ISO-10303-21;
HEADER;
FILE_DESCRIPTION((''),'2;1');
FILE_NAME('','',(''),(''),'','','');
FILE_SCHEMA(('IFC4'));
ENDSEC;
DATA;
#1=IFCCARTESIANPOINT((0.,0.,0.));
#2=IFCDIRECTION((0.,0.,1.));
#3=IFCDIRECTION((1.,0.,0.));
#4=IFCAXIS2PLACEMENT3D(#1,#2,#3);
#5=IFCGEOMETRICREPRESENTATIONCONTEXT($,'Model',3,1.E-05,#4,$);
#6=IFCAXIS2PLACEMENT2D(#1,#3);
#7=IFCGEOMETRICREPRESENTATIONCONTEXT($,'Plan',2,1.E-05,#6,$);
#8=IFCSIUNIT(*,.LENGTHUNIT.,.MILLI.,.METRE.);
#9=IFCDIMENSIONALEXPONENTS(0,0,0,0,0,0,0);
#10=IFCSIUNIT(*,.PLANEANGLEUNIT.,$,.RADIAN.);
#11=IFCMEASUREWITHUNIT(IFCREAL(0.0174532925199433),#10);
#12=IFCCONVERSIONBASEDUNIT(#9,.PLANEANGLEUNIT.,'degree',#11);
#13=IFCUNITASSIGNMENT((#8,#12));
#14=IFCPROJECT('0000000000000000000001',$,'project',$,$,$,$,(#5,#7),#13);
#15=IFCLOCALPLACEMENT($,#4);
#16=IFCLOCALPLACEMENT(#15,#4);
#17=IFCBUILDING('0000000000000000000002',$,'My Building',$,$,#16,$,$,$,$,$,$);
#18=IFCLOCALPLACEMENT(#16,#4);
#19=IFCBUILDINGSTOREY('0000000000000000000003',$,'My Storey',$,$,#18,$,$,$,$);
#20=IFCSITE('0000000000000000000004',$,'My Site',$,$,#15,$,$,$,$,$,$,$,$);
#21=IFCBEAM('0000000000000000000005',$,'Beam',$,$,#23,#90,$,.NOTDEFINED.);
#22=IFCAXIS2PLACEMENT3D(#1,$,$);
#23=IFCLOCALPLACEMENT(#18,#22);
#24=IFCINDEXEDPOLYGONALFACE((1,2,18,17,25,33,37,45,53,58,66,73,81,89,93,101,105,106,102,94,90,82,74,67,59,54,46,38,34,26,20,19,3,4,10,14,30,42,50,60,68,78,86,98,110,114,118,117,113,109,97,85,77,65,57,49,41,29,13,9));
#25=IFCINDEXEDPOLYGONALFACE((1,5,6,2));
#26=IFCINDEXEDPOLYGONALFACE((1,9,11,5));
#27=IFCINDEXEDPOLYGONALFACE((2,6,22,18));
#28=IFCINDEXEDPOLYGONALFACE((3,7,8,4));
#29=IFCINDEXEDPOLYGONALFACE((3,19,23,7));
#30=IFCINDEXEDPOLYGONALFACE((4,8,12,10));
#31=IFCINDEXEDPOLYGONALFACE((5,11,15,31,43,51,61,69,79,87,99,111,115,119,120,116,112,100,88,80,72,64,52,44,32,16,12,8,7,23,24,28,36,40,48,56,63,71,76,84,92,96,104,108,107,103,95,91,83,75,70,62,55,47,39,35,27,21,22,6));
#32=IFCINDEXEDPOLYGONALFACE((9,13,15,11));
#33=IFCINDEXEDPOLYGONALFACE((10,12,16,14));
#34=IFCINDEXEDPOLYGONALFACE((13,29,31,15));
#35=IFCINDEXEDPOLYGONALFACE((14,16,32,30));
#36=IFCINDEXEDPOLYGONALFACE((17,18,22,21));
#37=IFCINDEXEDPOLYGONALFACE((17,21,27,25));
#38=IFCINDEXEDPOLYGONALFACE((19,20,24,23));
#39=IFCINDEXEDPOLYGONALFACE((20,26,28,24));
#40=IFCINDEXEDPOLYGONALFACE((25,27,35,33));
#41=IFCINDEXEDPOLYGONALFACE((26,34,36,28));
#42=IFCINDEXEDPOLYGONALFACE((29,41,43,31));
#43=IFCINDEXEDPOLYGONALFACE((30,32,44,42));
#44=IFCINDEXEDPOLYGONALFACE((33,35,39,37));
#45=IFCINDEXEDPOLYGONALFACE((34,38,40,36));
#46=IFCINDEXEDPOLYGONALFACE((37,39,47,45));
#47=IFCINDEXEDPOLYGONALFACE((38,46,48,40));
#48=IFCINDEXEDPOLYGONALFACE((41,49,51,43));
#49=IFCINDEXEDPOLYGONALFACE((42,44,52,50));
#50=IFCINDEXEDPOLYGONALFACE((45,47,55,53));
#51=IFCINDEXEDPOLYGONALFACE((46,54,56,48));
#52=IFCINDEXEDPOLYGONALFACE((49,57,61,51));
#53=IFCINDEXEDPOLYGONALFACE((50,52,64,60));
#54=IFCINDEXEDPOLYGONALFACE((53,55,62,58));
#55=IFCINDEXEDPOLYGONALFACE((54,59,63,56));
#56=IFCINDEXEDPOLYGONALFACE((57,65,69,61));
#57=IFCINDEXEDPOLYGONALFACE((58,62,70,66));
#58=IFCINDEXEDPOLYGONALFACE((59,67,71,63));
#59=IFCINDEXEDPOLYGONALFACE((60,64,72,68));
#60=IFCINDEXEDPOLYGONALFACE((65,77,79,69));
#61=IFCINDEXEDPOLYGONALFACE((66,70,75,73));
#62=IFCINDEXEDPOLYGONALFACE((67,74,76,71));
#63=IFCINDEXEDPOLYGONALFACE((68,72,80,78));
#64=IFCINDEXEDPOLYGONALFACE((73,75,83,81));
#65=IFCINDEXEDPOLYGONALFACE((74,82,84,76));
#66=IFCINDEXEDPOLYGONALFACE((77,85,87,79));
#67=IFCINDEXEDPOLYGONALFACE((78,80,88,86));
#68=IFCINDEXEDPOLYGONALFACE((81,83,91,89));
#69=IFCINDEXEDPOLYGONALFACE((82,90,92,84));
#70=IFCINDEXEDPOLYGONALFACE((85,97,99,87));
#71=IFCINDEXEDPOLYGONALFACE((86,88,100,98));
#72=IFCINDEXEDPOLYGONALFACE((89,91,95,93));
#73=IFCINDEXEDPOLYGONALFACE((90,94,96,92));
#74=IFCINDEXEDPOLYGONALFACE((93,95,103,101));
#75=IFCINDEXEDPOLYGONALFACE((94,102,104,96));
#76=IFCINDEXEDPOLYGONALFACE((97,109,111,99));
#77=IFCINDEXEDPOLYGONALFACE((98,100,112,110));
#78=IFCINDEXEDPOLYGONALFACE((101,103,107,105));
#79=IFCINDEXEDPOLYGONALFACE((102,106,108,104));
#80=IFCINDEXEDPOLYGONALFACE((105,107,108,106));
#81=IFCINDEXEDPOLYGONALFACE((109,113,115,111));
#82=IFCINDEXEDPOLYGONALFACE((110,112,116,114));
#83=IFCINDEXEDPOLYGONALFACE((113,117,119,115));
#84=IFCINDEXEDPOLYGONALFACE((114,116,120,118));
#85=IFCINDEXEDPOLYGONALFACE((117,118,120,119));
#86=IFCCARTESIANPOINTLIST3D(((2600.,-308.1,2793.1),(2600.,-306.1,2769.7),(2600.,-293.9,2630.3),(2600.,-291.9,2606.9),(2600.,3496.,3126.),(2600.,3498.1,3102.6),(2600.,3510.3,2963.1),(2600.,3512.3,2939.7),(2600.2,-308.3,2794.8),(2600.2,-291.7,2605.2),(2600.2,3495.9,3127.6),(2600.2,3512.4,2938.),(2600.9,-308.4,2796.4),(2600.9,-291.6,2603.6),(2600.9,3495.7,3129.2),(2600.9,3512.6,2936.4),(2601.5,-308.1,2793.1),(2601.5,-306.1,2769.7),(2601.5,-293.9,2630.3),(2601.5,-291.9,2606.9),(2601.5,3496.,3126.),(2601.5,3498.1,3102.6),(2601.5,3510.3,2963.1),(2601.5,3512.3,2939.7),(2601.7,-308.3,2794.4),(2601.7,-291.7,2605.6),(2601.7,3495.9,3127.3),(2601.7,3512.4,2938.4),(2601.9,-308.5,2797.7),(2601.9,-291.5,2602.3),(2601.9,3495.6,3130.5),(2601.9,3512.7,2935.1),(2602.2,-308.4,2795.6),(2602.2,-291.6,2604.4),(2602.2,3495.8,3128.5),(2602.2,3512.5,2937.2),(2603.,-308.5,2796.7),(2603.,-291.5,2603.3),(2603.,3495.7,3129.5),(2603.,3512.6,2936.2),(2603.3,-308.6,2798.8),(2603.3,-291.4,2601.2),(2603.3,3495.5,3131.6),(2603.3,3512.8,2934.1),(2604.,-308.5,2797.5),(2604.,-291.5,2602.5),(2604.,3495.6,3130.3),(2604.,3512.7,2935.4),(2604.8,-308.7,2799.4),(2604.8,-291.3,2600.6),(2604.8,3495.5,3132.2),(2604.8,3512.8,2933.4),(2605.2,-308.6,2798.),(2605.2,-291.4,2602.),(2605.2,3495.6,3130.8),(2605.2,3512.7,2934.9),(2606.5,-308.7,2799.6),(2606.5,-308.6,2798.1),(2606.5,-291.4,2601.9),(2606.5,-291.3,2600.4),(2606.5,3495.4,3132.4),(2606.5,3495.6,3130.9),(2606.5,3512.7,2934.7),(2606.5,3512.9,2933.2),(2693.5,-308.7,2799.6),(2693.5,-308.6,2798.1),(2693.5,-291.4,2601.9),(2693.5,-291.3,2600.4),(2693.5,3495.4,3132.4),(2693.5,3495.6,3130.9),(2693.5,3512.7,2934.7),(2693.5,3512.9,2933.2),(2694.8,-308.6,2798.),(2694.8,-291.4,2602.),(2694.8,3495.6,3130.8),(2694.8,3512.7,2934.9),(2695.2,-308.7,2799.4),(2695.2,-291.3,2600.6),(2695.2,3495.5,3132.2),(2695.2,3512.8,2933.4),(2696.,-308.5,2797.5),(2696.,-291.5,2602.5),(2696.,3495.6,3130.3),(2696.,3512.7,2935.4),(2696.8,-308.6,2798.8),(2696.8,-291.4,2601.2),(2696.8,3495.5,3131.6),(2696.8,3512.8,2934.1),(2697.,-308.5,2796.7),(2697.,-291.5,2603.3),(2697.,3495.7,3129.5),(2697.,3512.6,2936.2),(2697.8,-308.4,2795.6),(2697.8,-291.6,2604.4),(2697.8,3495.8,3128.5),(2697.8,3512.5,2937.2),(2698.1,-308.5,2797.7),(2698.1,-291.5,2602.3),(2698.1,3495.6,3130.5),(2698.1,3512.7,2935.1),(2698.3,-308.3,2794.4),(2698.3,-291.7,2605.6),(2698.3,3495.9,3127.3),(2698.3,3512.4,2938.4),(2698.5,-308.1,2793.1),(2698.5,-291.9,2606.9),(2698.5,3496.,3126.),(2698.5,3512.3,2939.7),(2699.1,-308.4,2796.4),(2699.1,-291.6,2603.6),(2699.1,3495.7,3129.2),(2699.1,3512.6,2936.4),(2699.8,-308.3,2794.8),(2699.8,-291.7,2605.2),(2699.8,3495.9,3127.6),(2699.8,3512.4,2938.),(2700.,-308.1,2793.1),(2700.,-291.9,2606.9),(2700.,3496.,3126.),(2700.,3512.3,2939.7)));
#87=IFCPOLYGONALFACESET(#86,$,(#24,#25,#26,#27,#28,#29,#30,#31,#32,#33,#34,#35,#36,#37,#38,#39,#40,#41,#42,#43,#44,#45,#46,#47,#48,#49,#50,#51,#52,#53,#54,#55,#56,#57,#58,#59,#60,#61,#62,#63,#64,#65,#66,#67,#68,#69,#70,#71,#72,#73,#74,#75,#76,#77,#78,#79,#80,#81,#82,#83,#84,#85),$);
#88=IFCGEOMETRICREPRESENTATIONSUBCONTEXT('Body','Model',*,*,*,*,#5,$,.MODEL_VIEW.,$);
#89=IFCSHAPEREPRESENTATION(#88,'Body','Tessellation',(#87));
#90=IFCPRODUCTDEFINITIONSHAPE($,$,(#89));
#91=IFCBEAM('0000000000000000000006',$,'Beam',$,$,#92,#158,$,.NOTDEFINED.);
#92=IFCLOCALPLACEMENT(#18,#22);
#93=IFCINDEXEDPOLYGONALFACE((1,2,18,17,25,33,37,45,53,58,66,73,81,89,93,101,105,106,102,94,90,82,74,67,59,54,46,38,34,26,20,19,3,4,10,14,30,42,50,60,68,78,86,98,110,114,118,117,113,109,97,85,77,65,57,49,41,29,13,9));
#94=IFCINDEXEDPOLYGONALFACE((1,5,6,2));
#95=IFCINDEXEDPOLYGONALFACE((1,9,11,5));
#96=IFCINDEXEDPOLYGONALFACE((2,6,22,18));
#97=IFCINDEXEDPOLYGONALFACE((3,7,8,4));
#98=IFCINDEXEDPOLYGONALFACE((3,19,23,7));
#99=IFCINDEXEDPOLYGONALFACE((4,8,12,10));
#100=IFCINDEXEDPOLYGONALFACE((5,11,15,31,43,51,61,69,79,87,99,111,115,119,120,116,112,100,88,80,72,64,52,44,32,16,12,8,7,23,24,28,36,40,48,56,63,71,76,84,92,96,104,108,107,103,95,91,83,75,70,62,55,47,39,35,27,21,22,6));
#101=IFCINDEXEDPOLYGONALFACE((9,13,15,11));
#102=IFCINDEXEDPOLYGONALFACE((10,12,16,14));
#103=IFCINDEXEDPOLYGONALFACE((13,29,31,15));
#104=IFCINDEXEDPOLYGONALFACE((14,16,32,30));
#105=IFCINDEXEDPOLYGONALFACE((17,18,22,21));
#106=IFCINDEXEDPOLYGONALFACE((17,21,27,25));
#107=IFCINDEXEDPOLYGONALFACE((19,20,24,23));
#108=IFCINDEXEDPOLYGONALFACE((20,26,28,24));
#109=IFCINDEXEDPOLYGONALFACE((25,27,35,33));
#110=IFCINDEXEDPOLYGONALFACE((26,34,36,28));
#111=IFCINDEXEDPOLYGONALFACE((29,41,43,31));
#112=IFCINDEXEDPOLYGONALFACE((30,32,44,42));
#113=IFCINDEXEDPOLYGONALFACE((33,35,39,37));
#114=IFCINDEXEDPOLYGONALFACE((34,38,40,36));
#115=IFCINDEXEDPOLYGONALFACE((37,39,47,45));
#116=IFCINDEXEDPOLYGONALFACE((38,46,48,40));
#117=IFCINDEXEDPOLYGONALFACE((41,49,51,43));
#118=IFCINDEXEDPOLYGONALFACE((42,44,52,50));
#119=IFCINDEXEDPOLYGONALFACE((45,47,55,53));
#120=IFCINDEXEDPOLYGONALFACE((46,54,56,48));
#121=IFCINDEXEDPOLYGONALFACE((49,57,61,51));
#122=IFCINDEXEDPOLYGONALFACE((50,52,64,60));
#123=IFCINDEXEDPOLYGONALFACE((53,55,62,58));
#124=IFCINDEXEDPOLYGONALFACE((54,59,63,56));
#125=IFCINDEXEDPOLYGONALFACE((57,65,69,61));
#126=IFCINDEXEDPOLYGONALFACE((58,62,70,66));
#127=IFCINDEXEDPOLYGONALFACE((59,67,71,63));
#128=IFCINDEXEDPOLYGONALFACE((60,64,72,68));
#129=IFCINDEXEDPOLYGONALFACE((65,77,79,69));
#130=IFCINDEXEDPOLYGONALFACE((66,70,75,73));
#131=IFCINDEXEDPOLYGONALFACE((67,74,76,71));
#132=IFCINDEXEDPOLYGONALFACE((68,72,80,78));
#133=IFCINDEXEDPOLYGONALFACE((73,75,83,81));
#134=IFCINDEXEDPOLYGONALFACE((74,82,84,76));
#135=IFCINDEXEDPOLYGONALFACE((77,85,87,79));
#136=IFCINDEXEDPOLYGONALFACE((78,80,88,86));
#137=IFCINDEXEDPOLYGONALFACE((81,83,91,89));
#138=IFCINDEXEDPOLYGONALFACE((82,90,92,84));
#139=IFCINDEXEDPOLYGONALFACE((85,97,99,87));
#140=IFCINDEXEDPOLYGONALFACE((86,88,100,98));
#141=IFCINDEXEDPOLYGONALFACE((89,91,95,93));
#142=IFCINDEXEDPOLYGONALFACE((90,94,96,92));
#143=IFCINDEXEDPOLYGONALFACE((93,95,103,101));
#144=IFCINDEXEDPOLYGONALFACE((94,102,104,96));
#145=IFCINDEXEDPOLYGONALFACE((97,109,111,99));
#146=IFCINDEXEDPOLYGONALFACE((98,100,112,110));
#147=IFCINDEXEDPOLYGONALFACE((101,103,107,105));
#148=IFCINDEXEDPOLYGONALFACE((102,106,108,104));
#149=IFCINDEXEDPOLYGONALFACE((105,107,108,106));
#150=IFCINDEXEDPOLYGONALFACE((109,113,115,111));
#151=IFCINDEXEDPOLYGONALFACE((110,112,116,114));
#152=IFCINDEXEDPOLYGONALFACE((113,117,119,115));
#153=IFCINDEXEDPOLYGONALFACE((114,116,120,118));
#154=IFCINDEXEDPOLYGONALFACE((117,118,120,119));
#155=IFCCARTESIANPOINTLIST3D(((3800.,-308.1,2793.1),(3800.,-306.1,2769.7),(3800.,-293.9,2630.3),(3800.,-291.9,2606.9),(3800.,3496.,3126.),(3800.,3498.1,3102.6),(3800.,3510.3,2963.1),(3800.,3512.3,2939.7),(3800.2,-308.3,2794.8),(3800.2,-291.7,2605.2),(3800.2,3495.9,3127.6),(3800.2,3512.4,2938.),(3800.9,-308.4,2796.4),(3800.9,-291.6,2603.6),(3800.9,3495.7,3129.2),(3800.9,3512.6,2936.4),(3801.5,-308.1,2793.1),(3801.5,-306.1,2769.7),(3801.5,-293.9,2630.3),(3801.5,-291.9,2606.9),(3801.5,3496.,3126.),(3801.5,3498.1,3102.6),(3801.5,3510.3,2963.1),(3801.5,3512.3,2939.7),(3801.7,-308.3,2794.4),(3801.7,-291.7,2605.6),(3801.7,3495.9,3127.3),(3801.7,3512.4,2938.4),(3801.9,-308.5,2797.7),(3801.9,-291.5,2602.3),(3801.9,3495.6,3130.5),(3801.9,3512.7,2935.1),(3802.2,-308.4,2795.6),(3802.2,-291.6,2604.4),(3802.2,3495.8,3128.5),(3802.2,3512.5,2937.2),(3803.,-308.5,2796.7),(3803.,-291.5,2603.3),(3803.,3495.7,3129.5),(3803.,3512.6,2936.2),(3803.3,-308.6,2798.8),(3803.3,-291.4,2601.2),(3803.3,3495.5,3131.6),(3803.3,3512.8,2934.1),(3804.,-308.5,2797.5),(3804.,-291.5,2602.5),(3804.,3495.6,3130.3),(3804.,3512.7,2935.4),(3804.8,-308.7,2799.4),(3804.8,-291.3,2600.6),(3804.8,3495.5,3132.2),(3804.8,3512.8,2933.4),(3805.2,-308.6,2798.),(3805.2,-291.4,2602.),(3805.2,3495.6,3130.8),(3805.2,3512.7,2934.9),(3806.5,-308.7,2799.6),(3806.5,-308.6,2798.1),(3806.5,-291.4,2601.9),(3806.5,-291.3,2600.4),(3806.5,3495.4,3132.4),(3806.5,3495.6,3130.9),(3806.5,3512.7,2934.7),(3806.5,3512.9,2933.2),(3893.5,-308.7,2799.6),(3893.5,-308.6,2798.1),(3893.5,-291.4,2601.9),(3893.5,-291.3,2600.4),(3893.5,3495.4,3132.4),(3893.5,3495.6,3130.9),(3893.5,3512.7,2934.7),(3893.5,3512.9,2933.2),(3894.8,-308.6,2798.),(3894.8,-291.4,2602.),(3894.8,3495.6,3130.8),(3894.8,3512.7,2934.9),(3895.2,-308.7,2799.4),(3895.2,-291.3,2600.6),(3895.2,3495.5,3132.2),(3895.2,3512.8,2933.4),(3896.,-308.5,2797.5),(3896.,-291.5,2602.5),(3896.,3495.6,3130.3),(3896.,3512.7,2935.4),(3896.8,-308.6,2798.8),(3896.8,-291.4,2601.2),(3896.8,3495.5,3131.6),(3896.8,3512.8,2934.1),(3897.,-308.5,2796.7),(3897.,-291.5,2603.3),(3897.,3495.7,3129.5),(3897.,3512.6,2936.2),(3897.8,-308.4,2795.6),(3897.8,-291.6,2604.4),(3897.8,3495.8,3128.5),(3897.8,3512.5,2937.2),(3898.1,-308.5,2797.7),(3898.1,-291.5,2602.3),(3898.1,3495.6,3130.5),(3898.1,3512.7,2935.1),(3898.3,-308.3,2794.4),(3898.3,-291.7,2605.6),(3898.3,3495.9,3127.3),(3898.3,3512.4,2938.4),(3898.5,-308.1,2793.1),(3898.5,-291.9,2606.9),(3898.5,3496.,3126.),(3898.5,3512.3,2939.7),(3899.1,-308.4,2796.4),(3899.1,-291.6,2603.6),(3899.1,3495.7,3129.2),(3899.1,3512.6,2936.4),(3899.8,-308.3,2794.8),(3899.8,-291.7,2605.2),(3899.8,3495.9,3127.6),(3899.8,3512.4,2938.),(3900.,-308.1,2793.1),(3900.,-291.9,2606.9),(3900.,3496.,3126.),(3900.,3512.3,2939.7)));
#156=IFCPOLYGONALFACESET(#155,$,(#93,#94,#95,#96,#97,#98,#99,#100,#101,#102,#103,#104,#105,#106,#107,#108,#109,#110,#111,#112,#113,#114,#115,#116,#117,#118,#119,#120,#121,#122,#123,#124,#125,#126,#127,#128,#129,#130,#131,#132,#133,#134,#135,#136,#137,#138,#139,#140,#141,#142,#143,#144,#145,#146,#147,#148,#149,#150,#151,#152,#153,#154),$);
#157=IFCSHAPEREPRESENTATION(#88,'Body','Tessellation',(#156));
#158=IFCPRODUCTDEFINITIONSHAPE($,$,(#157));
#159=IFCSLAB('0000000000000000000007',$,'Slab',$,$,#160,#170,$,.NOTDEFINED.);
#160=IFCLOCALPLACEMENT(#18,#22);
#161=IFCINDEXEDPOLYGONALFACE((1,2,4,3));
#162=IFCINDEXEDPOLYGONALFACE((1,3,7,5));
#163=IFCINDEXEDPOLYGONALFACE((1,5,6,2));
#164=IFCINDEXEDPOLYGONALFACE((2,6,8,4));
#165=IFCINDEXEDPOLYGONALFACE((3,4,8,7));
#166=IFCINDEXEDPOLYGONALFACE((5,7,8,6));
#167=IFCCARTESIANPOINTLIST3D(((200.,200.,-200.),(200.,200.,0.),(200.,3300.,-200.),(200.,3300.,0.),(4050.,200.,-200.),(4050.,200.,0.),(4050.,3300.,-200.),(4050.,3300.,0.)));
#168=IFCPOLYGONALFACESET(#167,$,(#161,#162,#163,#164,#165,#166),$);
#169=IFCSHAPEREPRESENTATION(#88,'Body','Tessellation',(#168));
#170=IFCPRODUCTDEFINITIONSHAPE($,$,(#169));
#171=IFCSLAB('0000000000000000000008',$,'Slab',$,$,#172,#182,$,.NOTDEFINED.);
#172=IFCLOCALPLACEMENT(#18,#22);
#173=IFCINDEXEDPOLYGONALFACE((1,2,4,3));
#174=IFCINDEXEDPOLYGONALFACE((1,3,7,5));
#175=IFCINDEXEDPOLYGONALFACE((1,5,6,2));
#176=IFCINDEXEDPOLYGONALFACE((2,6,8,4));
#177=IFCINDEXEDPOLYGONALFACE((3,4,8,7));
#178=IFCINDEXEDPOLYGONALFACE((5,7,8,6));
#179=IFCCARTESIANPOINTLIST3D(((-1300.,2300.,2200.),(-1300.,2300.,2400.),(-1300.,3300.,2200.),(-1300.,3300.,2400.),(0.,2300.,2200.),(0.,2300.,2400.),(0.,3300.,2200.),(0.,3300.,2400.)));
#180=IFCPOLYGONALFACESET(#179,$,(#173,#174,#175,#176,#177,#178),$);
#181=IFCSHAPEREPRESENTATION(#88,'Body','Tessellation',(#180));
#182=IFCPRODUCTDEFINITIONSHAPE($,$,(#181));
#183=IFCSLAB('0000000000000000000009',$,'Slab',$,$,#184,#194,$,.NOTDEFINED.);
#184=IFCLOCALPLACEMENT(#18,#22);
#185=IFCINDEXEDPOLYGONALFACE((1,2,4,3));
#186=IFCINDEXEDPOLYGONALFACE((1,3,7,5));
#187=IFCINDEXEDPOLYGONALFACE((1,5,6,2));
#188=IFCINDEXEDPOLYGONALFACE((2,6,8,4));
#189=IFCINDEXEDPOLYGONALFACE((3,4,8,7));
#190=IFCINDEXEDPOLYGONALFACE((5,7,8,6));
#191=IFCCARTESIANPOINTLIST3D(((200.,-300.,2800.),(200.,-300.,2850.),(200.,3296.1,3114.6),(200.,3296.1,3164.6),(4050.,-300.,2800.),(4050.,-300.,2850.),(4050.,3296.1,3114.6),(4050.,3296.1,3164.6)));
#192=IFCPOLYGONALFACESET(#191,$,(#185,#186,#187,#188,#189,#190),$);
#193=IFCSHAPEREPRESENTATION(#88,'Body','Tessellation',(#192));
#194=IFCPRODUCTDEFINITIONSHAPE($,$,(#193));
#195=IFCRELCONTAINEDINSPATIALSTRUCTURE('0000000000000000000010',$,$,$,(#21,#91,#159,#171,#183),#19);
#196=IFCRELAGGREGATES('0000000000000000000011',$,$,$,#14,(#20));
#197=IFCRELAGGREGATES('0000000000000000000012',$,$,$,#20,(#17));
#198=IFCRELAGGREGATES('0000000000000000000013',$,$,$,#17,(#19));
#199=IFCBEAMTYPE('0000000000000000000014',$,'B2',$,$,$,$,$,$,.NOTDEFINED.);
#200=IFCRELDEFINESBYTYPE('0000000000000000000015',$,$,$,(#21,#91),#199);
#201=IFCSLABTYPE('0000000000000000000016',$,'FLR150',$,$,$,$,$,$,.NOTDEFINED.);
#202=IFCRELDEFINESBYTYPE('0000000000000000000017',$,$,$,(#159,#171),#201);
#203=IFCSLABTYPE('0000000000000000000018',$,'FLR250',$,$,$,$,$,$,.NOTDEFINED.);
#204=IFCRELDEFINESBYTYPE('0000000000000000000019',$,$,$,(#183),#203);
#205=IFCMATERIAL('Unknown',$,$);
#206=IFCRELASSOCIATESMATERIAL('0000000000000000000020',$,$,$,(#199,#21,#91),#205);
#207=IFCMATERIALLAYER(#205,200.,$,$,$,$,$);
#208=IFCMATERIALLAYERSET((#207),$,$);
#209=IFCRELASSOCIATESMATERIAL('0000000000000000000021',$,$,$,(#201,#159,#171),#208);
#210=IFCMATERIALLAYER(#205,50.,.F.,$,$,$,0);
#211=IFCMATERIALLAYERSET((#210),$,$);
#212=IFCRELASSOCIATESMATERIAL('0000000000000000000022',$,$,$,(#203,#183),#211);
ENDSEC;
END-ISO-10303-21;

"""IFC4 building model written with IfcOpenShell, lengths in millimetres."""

from ifc_helpers import new_model, entity, si_unit, converted_unit, frame, frame_2d, origin_with_axes, place, context, subcontext, project, spatial, line, indexed_curve, c_section, outline, extrude, material, layer, layer_set, layer_usage, material_profile, profile_set, profile_usage, type_object, element, save


model = new_model("IFC4")

# Units and contexts
model_context = context("Model", 3, precision=1e-05, world=origin_with_axes())
plan_context = context("Plan", 2, precision=1e-05, world=frame_2d((0.0, 0.0, 0.0), x_axis=(1.0, 0.0, 0.0)))
body_context = subcontext(model_context, "Body", "Model", "MODEL_VIEW")
ifc_project = project(units=[si_unit("LENGTHUNIT", "METRE", prefix="MILLI"), converted_unit("PLANEANGLEUNIT", "degree", entity("IfcReal", 0.0174532925199433), si_unit("PLANEANGLEUNIT", "RADIAN"), dimensions=[0, 0, 0, 0, 0, 0, 0])], contexts=[model_context, plan_context])

# Site, building, storey
site_placement = place(None, origin_with_axes())
site = spatial("IfcSite", under=ifc_project, at=site_placement, Name="My Site")
building_placement = place(site_placement, origin_with_axes())
building = spatial("IfcBuilding", under=site, at=building_placement, Name="My Building")
storey_placement = place(building_placement, origin_with_axes())
storey = spatial("IfcBuildingStorey", under=building, at=storey_placement, Name="My Storey")

# Shared definitions
ifc_material = material(Name="Unknown")

# Beams
ifc_material_profile_1 = material_profile(ifc_material, c_section(Depth=200.0, Width=100.0, WallThickness=1.5, Girth=30.0, InternalFilletRadius=5.0))
ifc_profile_set_1 = profile_set([ifc_material_profile_1])
beam_type_1 = type_object("IfcBeamType", Name="B2", PredefinedType="NOTDEFINED", material=ifc_profile_set_1)
ifc_profile_usage_1 = profile_usage(ifc_profile_set_1, cardinal=5)
beam_1_placement = place(storey_placement, frame((2650.0, -300.0, 2700.0), z_axis=(0.0, 0.996195, 0.087156), x_axis=(-1.0, 0.0, 0.0)))
element("IfcBeam", 1, at=beam_1_placement, inside=storey, type_object=beam_type_1, material=ifc_profile_usage_1, Name="Beam", PredefinedType="NOTDEFINED", context=body_context, shape_type="SweptSolid", body=[
    extrude(c_section(Depth=200.0, Width=100.0, WallThickness=1.5, Girth=30.0, InternalFilletRadius=5.0), origin_with_axes(), (0.0, 0.0, 1.0), 3818.7),
])
ifc_profile_usage_2 = profile_usage(ifc_profile_set_1, cardinal=5)
beam_2_placement = place(storey_placement, frame((3850.0, -300.0, 2700.0), z_axis=(0.0, 0.996195, 0.087156), x_axis=(-1.0, 0.0, 0.0)))
element("IfcBeam", 2, at=beam_2_placement, inside=storey, type_object=beam_type_1, material=ifc_profile_usage_2, Name="Beam", PredefinedType="NOTDEFINED", context=body_context, shape_type="SweptSolid", body=[
    extrude(c_section(Depth=200.0, Width=100.0, WallThickness=1.5, Girth=30.0, InternalFilletRadius=5.0), origin_with_axes(), (0.0, 0.0, 1.0), 3818.7),
])

# Slabs
ifc_layer_1 = layer(ifc_material, 200.0)
ifc_layer_set_1 = layer_set([ifc_layer_1])
ifc_layer_usage_1 = layer_usage(ifc_layer_set_1, "AXIS3", "POSITIVE", 0.0)
slab_type_1 = type_object("IfcSlabType", Name="FLR150", PredefinedType="NOTDEFINED", material=ifc_layer_set_1)
slab_1_placement = place(storey_placement, frame((200.0, 200.0, -200.0), z_axis=(0.0, 0.0, 1.0), x_axis=(1.0, 0.0, 0.0)))
element("IfcSlab", 3, at=slab_1_placement, inside=storey, type_object=slab_type_1, material=ifc_layer_usage_1, Name="Slab", PredefinedType="NOTDEFINED", context=body_context, shape_type="SweptSolid", body=[
    extrude(outline(indexed_curve([(0.0, 0.0), (3850.0, 0.0), (3850.0, 3100.0), (0.0, 3100.0)], segments=[line(3, 2), line(2, 1), line(1, 4), line(4, 3)], self_intersect=False)), None, (0.0, 0.0, 1.0), 200.0),
])
ifc_layer_usage_2 = layer_usage(ifc_layer_set_1, "AXIS3", "POSITIVE", 0.0)
slab_2_placement = place(storey_placement, frame((-1300.0, 2300.0, 2200.0), z_axis=(0.0, 0.0, 1.0), x_axis=(1.0, 0.0, 0.0)))
element("IfcSlab", 4, at=slab_2_placement, inside=storey, type_object=slab_type_1, material=ifc_layer_usage_2, Name="Slab", PredefinedType="NOTDEFINED", context=body_context, shape_type="SweptSolid", body=[
    extrude(outline(indexed_curve([(0.0, 0.0), (1300.0, 0.0), (1300.0, 1000.0), (0.0, 1000.0)], segments=[line(3, 2), line(2, 1), line(1, 4), line(4, 3)], self_intersect=False)), None, (0.0, 0.0, 1.0), 200.0),
])
ifc_layer_2 = layer(ifc_material, 50.0, ventilated=False, Priority=0)
ifc_layer_set_2 = layer_set([ifc_layer_2])
ifc_layer_usage_3 = layer_usage(ifc_layer_set_2, "AXIS3", "POSITIVE", 0.0)
slab_type_2 = type_object("IfcSlabType", Name="FLR250", PredefinedType="NOTDEFINED", material=ifc_layer_set_2)
slab_3_placement = place(storey_placement, frame((200.0, -300.0, 2800.0), z_axis=(0.0, -0.087156, 0.996195), x_axis=(1.0, 0.0, 0.0)))
element("IfcSlab", 5, at=slab_3_placement, inside=storey, type_object=slab_type_2, material=ifc_layer_usage_3, Name="Slab", PredefinedType="NOTDEFINED", context=body_context, shape_type="SweptSolid", body=[
    extrude(outline(indexed_curve([(3850.0, 3609.8), (3850.0, 0.0), (0.0, 0.0), (0.0, 3609.8)], segments=[line(3, 2), line(2, 1), line(1, 4), line(4, 3)], self_intersect=False)), None, (0.0, 0.087156, 0.996195), 50.0),
])

save(model, "model.ifc")
